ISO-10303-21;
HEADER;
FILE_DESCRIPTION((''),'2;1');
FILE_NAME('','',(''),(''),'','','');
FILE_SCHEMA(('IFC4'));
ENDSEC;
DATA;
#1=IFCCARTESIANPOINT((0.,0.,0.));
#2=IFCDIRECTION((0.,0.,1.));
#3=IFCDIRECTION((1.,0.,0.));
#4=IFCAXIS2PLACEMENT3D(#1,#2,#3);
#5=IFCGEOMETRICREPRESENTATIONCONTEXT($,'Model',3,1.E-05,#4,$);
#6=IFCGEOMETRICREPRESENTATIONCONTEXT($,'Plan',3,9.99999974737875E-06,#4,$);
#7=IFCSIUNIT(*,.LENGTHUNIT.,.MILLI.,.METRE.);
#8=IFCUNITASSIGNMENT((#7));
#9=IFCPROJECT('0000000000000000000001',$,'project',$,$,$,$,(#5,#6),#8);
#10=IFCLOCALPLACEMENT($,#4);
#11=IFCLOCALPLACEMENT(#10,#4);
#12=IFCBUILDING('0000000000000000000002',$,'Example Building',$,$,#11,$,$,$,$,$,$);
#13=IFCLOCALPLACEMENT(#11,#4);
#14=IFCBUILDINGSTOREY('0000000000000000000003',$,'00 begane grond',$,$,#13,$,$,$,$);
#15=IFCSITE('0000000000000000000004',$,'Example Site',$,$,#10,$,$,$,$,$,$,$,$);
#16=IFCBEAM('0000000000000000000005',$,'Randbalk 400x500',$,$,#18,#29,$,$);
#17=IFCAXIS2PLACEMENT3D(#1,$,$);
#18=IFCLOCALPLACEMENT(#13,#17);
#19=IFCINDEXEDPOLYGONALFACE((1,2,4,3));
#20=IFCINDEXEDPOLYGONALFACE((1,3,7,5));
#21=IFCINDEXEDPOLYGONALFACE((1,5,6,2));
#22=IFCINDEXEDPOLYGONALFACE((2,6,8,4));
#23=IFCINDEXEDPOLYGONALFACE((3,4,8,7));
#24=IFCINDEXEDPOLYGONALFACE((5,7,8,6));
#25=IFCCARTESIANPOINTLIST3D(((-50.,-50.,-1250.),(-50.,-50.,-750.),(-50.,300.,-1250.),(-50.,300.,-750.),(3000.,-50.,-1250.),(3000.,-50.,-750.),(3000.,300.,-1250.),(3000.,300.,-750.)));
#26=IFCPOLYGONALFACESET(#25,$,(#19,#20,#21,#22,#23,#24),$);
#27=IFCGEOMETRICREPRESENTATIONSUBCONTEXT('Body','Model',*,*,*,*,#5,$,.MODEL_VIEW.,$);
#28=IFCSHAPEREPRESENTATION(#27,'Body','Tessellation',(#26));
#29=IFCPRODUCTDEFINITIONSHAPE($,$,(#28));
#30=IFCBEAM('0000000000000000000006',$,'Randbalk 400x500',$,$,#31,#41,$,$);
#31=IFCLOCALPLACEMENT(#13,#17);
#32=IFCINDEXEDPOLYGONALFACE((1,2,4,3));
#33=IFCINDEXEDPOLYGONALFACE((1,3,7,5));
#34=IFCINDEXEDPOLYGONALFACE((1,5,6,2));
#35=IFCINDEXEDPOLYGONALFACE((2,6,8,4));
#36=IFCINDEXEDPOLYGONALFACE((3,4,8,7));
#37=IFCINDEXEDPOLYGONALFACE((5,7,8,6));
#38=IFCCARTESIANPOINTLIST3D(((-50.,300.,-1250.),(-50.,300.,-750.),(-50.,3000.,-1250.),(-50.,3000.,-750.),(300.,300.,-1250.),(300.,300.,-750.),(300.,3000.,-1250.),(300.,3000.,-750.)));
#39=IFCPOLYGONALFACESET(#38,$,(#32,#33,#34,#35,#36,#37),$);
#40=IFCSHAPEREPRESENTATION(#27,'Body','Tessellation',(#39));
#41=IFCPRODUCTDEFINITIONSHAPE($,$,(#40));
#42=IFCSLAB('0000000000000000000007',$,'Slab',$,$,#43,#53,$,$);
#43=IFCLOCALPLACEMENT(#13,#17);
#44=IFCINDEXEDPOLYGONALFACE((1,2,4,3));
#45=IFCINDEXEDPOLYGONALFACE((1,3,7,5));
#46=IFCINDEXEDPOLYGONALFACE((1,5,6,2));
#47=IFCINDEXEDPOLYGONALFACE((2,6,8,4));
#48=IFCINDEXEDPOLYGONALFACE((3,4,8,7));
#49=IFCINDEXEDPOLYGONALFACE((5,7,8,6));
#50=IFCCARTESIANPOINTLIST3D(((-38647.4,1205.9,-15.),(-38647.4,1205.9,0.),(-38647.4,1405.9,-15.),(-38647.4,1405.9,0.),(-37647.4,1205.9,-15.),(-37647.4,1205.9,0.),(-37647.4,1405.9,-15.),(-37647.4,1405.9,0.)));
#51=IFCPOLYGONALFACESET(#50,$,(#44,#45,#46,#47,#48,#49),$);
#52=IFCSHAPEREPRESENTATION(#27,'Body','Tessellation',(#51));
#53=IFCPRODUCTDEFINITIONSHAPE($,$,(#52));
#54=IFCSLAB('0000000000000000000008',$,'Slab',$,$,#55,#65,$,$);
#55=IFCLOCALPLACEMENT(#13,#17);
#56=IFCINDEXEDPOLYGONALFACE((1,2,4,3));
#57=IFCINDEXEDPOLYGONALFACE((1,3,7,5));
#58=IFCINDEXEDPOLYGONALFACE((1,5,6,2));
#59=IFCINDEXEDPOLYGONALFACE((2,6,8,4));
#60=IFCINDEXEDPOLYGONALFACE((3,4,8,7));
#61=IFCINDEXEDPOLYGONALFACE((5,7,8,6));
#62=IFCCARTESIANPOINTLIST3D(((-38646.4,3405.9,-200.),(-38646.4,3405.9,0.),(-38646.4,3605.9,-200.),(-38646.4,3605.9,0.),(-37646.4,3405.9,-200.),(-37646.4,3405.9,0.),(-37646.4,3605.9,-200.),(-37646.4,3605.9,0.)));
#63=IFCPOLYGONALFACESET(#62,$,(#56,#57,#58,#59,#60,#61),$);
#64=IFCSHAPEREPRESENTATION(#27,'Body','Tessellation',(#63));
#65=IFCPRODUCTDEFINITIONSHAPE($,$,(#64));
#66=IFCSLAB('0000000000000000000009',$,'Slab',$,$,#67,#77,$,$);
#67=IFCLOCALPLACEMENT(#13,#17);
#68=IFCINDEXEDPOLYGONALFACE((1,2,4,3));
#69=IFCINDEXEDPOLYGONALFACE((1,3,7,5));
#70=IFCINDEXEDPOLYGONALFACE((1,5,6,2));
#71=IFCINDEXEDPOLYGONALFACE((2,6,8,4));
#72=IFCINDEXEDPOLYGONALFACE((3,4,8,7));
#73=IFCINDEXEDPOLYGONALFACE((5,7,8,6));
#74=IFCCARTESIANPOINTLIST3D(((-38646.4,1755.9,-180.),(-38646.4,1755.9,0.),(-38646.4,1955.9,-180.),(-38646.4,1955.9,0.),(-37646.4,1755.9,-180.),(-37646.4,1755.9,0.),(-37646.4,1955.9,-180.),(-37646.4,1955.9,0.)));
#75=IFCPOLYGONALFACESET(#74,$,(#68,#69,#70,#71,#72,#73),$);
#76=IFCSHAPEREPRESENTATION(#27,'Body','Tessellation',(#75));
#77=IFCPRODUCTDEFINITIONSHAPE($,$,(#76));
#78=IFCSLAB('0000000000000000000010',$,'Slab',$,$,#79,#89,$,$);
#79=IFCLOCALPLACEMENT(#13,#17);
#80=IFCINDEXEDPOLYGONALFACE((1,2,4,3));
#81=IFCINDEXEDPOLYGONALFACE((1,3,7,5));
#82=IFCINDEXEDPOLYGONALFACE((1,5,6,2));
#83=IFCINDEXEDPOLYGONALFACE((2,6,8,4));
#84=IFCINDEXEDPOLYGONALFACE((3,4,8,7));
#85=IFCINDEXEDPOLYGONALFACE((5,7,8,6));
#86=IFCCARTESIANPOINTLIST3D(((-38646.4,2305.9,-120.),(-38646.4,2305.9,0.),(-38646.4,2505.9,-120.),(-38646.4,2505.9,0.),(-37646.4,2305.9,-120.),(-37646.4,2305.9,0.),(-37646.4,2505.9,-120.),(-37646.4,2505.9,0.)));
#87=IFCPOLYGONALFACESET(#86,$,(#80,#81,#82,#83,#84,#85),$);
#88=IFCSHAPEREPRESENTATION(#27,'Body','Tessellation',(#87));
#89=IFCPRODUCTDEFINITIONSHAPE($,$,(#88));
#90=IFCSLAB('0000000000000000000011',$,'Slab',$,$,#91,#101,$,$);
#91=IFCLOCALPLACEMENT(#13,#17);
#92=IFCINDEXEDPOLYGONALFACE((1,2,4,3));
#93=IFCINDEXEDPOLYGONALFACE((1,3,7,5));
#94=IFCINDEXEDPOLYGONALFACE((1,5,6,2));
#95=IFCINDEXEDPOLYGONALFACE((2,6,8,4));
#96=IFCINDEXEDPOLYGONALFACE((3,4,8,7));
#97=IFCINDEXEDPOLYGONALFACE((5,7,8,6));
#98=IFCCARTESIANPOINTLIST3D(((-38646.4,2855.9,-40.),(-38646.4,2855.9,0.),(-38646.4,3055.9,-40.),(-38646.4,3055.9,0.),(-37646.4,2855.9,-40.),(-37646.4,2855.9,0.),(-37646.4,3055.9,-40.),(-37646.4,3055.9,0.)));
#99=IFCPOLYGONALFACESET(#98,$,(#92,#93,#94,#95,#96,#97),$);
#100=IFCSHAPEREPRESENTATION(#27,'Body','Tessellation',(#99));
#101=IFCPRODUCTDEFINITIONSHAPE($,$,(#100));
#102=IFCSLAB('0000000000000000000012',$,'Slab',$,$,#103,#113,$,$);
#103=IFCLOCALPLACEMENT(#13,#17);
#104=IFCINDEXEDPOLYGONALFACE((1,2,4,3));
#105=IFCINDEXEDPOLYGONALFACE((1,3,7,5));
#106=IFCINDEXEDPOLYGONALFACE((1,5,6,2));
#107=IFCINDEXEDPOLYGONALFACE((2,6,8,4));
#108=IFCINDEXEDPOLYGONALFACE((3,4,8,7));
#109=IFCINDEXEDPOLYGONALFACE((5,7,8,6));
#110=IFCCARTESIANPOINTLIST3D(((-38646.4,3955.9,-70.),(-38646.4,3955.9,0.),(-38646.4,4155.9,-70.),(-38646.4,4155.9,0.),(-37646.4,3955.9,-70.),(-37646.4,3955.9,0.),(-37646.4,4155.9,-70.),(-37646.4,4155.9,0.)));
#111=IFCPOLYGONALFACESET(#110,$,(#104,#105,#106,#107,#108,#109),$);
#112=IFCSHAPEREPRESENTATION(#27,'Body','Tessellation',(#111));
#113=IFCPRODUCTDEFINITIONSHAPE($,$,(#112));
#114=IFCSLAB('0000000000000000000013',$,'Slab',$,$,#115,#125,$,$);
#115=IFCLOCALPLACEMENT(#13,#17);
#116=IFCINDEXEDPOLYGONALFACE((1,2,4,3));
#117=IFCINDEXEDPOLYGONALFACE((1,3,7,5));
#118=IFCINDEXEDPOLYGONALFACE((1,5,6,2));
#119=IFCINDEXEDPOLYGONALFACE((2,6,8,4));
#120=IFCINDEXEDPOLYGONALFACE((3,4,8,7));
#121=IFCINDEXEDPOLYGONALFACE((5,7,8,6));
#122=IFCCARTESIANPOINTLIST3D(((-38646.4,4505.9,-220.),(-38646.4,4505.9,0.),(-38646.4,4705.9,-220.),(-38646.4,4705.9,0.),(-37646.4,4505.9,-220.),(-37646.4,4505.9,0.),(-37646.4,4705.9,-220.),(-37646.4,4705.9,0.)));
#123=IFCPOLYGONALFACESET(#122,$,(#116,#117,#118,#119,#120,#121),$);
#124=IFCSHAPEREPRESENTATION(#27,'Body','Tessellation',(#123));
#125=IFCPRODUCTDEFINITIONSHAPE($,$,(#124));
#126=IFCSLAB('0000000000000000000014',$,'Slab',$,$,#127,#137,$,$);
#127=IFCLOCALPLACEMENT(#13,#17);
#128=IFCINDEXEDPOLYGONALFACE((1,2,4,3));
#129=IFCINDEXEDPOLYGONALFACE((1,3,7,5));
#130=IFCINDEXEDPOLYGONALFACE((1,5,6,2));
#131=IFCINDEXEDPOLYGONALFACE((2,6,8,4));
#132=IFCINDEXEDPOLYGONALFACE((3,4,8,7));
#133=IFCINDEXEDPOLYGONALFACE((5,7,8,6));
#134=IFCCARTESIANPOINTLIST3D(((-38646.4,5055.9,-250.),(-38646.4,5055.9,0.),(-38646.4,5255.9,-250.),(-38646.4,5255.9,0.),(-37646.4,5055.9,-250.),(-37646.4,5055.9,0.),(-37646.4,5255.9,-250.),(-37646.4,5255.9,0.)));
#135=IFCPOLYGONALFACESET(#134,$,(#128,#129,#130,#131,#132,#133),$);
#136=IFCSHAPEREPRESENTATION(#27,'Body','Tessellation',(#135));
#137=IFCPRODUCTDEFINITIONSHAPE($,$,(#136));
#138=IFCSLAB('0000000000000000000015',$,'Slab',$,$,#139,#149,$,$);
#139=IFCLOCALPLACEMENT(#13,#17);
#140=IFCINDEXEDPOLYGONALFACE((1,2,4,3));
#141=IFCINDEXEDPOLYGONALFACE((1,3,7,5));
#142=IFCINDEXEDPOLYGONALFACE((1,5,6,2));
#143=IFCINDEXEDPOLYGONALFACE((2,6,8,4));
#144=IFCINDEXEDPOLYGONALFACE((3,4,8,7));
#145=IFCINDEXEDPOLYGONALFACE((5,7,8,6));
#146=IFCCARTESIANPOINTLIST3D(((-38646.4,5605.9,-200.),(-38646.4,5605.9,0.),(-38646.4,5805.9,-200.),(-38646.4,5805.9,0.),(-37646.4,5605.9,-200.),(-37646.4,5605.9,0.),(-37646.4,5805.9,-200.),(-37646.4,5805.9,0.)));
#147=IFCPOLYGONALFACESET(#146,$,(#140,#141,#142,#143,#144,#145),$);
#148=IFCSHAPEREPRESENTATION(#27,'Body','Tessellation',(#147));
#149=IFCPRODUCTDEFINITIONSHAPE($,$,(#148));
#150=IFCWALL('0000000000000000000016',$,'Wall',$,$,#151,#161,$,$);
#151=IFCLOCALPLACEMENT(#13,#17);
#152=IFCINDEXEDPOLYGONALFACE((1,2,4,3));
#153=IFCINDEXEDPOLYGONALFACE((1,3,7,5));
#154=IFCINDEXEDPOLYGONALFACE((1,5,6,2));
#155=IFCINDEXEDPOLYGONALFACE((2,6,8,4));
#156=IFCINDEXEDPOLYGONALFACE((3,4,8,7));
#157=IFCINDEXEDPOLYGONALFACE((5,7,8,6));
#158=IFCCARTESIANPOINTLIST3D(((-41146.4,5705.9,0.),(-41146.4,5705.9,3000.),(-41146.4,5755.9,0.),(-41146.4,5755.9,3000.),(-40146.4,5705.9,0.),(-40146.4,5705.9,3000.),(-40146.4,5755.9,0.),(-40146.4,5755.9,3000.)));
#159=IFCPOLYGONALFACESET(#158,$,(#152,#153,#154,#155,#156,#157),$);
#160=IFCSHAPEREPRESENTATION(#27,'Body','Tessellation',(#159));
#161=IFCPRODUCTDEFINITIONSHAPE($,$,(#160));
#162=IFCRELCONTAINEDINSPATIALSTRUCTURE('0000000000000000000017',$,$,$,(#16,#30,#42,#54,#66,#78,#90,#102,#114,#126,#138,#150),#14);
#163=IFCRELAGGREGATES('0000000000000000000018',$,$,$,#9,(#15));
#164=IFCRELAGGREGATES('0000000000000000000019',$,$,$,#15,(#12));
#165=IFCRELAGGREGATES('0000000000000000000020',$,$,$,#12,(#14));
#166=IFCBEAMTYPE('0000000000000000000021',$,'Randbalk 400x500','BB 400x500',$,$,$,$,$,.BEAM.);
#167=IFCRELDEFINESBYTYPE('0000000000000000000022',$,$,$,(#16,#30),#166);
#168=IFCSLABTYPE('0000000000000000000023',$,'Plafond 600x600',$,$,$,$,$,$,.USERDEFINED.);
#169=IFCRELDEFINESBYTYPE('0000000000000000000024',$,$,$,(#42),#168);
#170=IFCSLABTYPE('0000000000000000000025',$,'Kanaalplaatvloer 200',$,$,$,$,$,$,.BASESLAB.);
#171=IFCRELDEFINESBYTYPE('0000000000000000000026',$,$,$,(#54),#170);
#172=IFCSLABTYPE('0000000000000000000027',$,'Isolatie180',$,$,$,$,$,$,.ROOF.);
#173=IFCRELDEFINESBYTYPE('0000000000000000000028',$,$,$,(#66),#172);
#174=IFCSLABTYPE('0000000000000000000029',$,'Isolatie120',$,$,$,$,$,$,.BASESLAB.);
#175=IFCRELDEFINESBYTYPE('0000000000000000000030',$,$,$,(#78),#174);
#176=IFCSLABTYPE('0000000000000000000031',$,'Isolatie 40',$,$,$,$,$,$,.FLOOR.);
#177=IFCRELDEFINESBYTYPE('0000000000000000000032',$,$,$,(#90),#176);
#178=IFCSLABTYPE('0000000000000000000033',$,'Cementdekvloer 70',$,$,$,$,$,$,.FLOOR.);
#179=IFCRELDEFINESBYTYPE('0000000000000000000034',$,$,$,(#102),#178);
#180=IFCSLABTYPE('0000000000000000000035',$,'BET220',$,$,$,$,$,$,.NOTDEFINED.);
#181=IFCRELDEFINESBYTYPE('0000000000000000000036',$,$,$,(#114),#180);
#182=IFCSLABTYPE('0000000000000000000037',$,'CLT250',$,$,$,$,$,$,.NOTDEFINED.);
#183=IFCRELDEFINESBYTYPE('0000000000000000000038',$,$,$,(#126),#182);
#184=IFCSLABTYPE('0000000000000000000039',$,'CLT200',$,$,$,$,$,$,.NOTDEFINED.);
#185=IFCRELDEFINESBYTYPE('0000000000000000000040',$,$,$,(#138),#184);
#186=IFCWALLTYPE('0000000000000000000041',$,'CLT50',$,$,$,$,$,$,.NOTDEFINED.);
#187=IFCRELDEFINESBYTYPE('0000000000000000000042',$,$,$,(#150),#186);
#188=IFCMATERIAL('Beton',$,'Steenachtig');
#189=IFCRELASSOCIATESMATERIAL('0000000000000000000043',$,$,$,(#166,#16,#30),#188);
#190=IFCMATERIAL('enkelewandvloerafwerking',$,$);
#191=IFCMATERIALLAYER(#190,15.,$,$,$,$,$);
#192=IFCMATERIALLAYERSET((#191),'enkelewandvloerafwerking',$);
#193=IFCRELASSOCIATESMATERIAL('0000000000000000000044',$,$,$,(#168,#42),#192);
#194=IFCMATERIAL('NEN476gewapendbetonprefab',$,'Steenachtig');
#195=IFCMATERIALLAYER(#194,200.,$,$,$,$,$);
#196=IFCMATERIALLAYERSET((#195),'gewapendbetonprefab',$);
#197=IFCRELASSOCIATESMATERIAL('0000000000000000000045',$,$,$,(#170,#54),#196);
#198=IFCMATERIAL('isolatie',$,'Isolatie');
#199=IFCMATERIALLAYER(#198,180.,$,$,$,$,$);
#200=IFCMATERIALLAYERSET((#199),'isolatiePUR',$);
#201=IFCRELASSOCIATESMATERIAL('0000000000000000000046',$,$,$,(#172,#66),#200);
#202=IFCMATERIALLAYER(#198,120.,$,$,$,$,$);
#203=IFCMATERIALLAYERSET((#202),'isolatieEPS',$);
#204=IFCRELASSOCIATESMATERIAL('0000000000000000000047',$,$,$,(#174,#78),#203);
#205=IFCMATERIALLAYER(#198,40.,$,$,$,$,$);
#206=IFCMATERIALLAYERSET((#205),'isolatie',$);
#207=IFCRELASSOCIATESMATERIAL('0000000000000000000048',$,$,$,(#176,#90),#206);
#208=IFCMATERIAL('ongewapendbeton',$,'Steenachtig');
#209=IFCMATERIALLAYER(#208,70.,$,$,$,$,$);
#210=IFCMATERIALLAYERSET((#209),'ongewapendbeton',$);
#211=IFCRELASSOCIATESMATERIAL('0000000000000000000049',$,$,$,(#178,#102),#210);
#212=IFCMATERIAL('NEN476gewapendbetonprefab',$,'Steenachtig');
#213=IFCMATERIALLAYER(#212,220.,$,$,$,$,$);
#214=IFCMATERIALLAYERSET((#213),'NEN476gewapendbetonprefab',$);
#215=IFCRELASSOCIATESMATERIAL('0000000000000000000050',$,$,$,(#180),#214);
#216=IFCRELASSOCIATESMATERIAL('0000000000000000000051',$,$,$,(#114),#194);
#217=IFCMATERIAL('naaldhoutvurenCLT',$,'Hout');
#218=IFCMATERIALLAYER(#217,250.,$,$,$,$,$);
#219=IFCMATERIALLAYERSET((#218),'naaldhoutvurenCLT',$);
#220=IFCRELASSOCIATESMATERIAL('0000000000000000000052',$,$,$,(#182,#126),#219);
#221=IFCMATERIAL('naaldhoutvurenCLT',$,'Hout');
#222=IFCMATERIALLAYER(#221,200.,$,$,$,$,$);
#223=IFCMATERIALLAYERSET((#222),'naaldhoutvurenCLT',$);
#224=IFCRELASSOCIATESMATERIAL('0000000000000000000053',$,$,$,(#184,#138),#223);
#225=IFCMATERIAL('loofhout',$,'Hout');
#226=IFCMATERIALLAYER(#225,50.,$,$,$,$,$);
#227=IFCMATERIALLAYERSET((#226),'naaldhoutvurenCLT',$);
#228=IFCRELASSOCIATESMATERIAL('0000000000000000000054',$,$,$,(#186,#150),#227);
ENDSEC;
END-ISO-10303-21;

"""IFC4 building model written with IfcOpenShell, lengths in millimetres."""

from ifc_helpers import new_model, si_unit, frame, origin_with_axes, place, context, subcontext, project, spatial, line, indexed_curve, rectangle, outline, extrude, material, layer, layer_set, layer_usage, material_profile, profile_set, profile_usage, type_object, element, save


model = new_model("IFC4")

# Units and contexts
model_context = context("Model", 3, precision=1e-05, world=origin_with_axes())
plan_context = context("Plan", 3, precision=9.99999974737875e-06, world=origin_with_axes())
body_context = subcontext(model_context, "Body", "Model", "MODEL_VIEW")
ifc_project = project(units=[si_unit("LENGTHUNIT", "METRE", prefix="MILLI")], contexts=[model_context, plan_context])

# Site, building, storey
site_placement = place(None, frame((0.0, 0.0, 0.0), z_axis=(0.0, 0.0, 1.0), x_axis=(1.0, 0.0, 0.0)))
site = spatial("IfcSite", under=ifc_project, at=site_placement, Name="Example Site")
building_placement = place(site_placement, origin_with_axes())
building = spatial("IfcBuilding", under=site, at=building_placement, Name="Example Building")
storey_placement = place(building_placement, origin_with_axes())
storey = spatial("IfcBuildingStorey", under=building, at=storey_placement, Name="00 begane grond")

# Beams
ifc_material_1 = material(Name="Beton", Category="Steenachtig")
ifc_material_profile = material_profile(ifc_material_1, rectangle(XDim=350.0, YDim=500.0, kind="CURVE"))
ifc_profile_set = profile_set([ifc_material_profile], Name="gewapendbeton")
ifc_profile_usage_1 = profile_usage(ifc_profile_set, cardinal=5)
beam_type = type_object("IfcBeamType", Name="Randbalk 400x500", Description="BB 400x500", PredefinedType="BEAM", material=ifc_profile_set)
beam_1_placement = place(storey_placement, frame((-50.0, 125.0, -1000.0), z_axis=(1.0, 0.0, 0.0), x_axis=(0.0, 1.0, 0.0)))
element("IfcBeam", 1, at=beam_1_placement, inside=storey, type_object=beam_type, material=ifc_profile_usage_1, Name="Randbalk 400x500", context=body_context, shape_type="SweptSolid", body=[
    extrude(rectangle(XDim=350.0, YDim=500.0, kind="CURVE"), origin_with_axes(), (0.0, 0.0, 1.0), 3050.0),
])
ifc_profile_usage_2 = profile_usage(ifc_profile_set, cardinal=5)
beam_2_placement = place(storey_placement, frame((125.0, 300.0, -1000.0), z_axis=(0.0, 1.0, 0.0), x_axis=(-1.0, 0.0, 0.0)))
element("IfcBeam", 2, at=beam_2_placement, inside=storey, type_object=beam_type, material=ifc_profile_usage_2, Name="Randbalk 400x500", context=body_context, shape_type="SweptSolid", body=[
    extrude(rectangle(XDim=350.0, YDim=500.0, kind="CURVE"), origin_with_axes(), (0.0, 0.0, 1.0), 2700.0),
])

# Slabs
ifc_material_2 = material(Name="enkelewandvloerafwerking")
ifc_layer_1 = layer(ifc_material_2, 15.0)
ifc_layer_set_1 = layer_set([ifc_layer_1], Name="enkelewandvloerafwerking")
ifc_layer_usage_1 = layer_usage(ifc_layer_set_1, "AXIS3", "POSITIVE", 0.0)
slab_type_1 = type_object("IfcSlabType", Name="Plafond 600x600", PredefinedType="USERDEFINED", material=ifc_layer_set_1)
slab_1_placement = place(storey_placement, frame((-38647.4, 1205.9, -15.0), z_axis=(0.0, 0.0, 1.0), x_axis=(1.0, 0.0, 0.0)))
element("IfcSlab", 3, at=slab_1_placement, inside=storey, type_object=slab_type_1, material=ifc_layer_usage_1, Name="Slab", context=body_context, shape_type="SweptSolid", body=[
    extrude(outline(indexed_curve([(1000.0, 200.0), (1000.0, 0.0), (0.0, 0.0), (0.0, 200.0)], segments=[line(4, 1), line(1, 2), line(2, 3), line(3, 4)], self_intersect=False)), None, (0.0, 0.0, 1.0), 15.0),
])
ifc_material_3 = material(Name="NEN476gewapendbetonprefab", Category="Steenachtig")
ifc_layer_2 = layer(ifc_material_3, 200.0)
ifc_layer_set_2 = layer_set([ifc_layer_2], Name="gewapendbetonprefab")
ifc_layer_usage_2 = layer_usage(ifc_layer_set_2, "AXIS3", "POSITIVE", 0.0)
slab_type_2 = type_object("IfcSlabType", Name="Kanaalplaatvloer 200", PredefinedType="BASESLAB", material=ifc_layer_set_2)
slab_2_placement = place(storey_placement, frame((-38646.4, 3405.9, -200.0), z_axis=(0.0, 0.0, 1.0), x_axis=(1.0, 0.0, 0.0)))
element("IfcSlab", 4, at=slab_2_placement, inside=storey, type_object=slab_type_2, material=ifc_layer_usage_2, Name="Slab", context=body_context, shape_type="SweptSolid", body=[
    extrude(outline(indexed_curve([(1000.0, 200.0), (1000.0, 0.0), (0.0, 0.0), (0.0, 200.0)], segments=[line(4, 1), line(1, 2), line(2, 3), line(3, 4)], self_intersect=False)), None, (0.0, 0.0, 1.0), 200.0),
])
ifc_material_4 = material(Name="isolatie", Category="Isolatie")
ifc_layer_3 = layer(ifc_material_4, 180.0)
ifc_layer_set_3 = layer_set([ifc_layer_3], Name="isolatiePUR")
ifc_layer_usage_3 = layer_usage(ifc_layer_set_3, "AXIS3", "POSITIVE", 0.0)
slab_type_3 = type_object("IfcSlabType", Name="Isolatie180", PredefinedType="ROOF", material=ifc_layer_set_3)
slab_3_placement = place(storey_placement, frame((-38646.4, 1755.9, -180.0), z_axis=(0.0, 0.0, 1.0), x_axis=(1.0, 0.0, 0.0)))
element("IfcSlab", 5, at=slab_3_placement, inside=storey, type_object=slab_type_3, material=ifc_layer_usage_3, Name="Slab", context=body_context, shape_type="SweptSolid", body=[
    extrude(outline(indexed_curve([(1000.0, 200.0), (1000.0, 0.0), (0.0, 0.0), (0.0, 200.0)], segments=[line(4, 1), line(1, 2), line(2, 3), line(3, 4)], self_intersect=False)), None, (0.0, 0.0, 1.0), 180.0),
])
ifc_layer_4 = layer(ifc_material_4, 120.0)
ifc_layer_set_4 = layer_set([ifc_layer_4], Name="isolatieEPS")
ifc_layer_usage_4 = layer_usage(ifc_layer_set_4, "AXIS3", "POSITIVE", 0.0)
slab_type_4 = type_object("IfcSlabType", Name="Isolatie120", PredefinedType="BASESLAB", material=ifc_layer_set_4)
slab_4_placement = place(storey_placement, frame((-38646.4, 2305.9, -120.0), z_axis=(0.0, 0.0, 1.0), x_axis=(1.0, 0.0, 0.0)))
element("IfcSlab", 6, at=slab_4_placement, inside=storey, type_object=slab_type_4, material=ifc_layer_usage_4, Name="Slab", context=body_context, shape_type="SweptSolid", body=[
    extrude(outline(indexed_curve([(1000.0, 200.0), (1000.0, 0.0), (0.0, 0.0), (0.0, 200.0)], segments=[line(3, 2), line(2, 1), line(1, 4), line(4, 3)], self_intersect=False)), None, (0.0, 0.0, 1.0), 120.0),
])
ifc_layer_5 = layer(ifc_material_4, 40.0)
ifc_layer_set_5 = layer_set([ifc_layer_5], Name="isolatie")
ifc_layer_usage_5 = layer_usage(ifc_layer_set_5, "AXIS3", "POSITIVE", 0.0)
slab_type_5 = type_object("IfcSlabType", Name="Isolatie 40", PredefinedType="FLOOR", material=ifc_layer_set_5)
slab_5_placement = place(storey_placement, frame((-38646.4, 2855.9, -40.0), z_axis=(0.0, 0.0, 1.0), x_axis=(1.0, 0.0, 0.0)))
element("IfcSlab", 7, at=slab_5_placement, inside=storey, type_object=slab_type_5, material=ifc_layer_usage_5, Name="Slab", context=body_context, shape_type="SweptSolid", body=[
    extrude(outline(indexed_curve([(1000.0, 200.0), (1000.0, 0.0), (0.0, 0.0), (0.0, 200.0)], segments=[line(3, 2), line(2, 1), line(1, 4), line(4, 3)], self_intersect=False)), None, (0.0, 0.0, 1.0), 40.0),
])
ifc_material_5 = material(Name="ongewapendbeton", Category="Steenachtig")
ifc_layer_6 = layer(ifc_material_5, 70.0)
ifc_layer_set_6 = layer_set([ifc_layer_6], Name="ongewapendbeton")
ifc_layer_usage_6 = layer_usage(ifc_layer_set_6, "AXIS3", "POSITIVE", 0.0)
slab_type_6 = type_object("IfcSlabType", Name="Cementdekvloer 70", PredefinedType="FLOOR", material=ifc_layer_set_6)
slab_6_placement = place(storey_placement, frame((-38646.4, 3955.9, -70.0), z_axis=(0.0, 0.0, 1.0), x_axis=(1.0, 0.0, 0.0)))
element("IfcSlab", 8, at=slab_6_placement, inside=storey, type_object=slab_type_6, material=ifc_layer_usage_6, Name="Slab", context=body_context, shape_type="SweptSolid", body=[
    extrude(outline(indexed_curve([(1000.0, 200.0), (1000.0, 0.0), (0.0, 0.0), (0.0, 200.0)], segments=[line(4, 1), line(1, 2), line(2, 3), line(3, 4)], self_intersect=False)), None, (0.0, 0.0, 1.0), 70.0),
])
ifc_material_6 = material(Name="NEN476gewapendbetonprefab", Category="Steenachtig")
ifc_layer_7 = layer(ifc_material_6, 220.0)
ifc_layer_set_7 = layer_set([ifc_layer_7], Name="NEN476gewapendbetonprefab")
slab_type_7 = type_object("IfcSlabType", Name="BET220", PredefinedType="NOTDEFINED", material=ifc_layer_set_7)
slab_7_placement = place(storey_placement, frame((-38646.4, 4505.9, -220.0), z_axis=(0.0, 0.0, 1.0), x_axis=(1.0, 0.0, 0.0)))
element("IfcSlab", 9, at=slab_7_placement, inside=storey, type_object=slab_type_7, material=ifc_material_3, Name="Slab", context=body_context, shape_type="SweptSolid", body=[
    extrude(outline(indexed_curve([(1000.0, 200.0), (1000.0, 0.0), (0.0, 0.0), (0.0, 200.0)], segments=[line(4, 1), line(1, 2), line(2, 3), line(3, 4)], self_intersect=False)), None, (0.0, 0.0, 1.0), 220.0),
])
ifc_material_7 = material(Name="naaldhoutvurenCLT", Category="Hout")
ifc_layer_8 = layer(ifc_material_7, 250.0)
ifc_layer_set_8 = layer_set([ifc_layer_8], Name="naaldhoutvurenCLT")
ifc_layer_usage_7 = layer_usage(ifc_layer_set_8, "AXIS3", "POSITIVE", 0.0)
slab_type_8 = type_object("IfcSlabType", Name="CLT250", PredefinedType="NOTDEFINED", material=ifc_layer_set_8)
slab_8_placement = place(storey_placement, frame((-38646.4, 5055.9, -250.0), z_axis=(0.0, 0.0, 1.0), x_axis=(1.0, 0.0, 0.0)))
element("IfcSlab", 10, at=slab_8_placement, inside=storey, type_object=slab_type_8, material=ifc_layer_usage_7, Name="Slab", context=body_context, shape_type="SweptSolid", body=[
    extrude(outline(indexed_curve([(1000.0, 200.0), (1000.0, 0.0), (0.0, 0.0), (0.0, 200.0)], segments=[line(3, 2), line(2, 1), line(1, 4), line(4, 3)], self_intersect=False)), None, (0.0, 0.0, 1.0), 250.0),
])
ifc_material_8 = material(Name="naaldhoutvurenCLT", Category="Hout")
ifc_layer_9 = layer(ifc_material_8, 200.0)
ifc_layer_set_9 = layer_set([ifc_layer_9], Name="naaldhoutvurenCLT")
ifc_layer_usage_8 = layer_usage(ifc_layer_set_9, "AXIS3", "POSITIVE", 0.0)
slab_type_9 = type_object("IfcSlabType", Name="CLT200", PredefinedType="NOTDEFINED", material=ifc_layer_set_9)
slab_9_placement = place(storey_placement, frame((-38646.4, 5605.9, -200.0), z_axis=(0.0, 0.0, 1.0), x_axis=(1.0, 0.0, 0.0)))
element("IfcSlab", 11, at=slab_9_placement, inside=storey, type_object=slab_type_9, material=ifc_layer_usage_8, Name="Slab", context=body_context, shape_type="SweptSolid", body=[
    extrude(outline(indexed_curve([(1000.0, 200.0), (1000.0, 0.0), (0.0, 0.0), (0.0, 200.0)], segments=[line(3, 2), line(2, 1), line(1, 4), line(4, 3)], self_intersect=False)), None, (0.0, 0.0, 1.0), 200.0),
])

# Wall
ifc_material_9 = material(Name="loofhout", Category="Hout")
ifc_layer_10 = layer(ifc_material_9, 50.0)
ifc_layer_set_10 = layer_set([ifc_layer_10], Name="naaldhoutvurenCLT")
ifc_layer_usage_9 = layer_usage(ifc_layer_set_10, "AXIS2", "POSITIVE", 0.0)
wall_type_1 = type_object("IfcWallType", Name="CLT50", PredefinedType="NOTDEFINED", material=ifc_layer_set_10)
wall_1_placement = place(storey_placement, frame((-41146.4, 5705.9, 0.0), z_axis=(0.0, 0.0, 1.0), x_axis=(1.0, 0.0, 0.0)))
element("IfcWall", 12, at=wall_1_placement, inside=storey, type_object=wall_type_1, material=ifc_layer_usage_9, Name="Wall", context=body_context, shape_type="SweptSolid", body=[
    extrude(outline(indexed_curve([(0.0, 0.0), (0.0, 50.0), (1000.0, 50.0), (1000.0, 0.0), (0.0, 0.0)], self_intersect=False)), origin_with_axes(), (0.0, 0.0, 1.0), 3000.0),
])

save(model, "model.ifc")
